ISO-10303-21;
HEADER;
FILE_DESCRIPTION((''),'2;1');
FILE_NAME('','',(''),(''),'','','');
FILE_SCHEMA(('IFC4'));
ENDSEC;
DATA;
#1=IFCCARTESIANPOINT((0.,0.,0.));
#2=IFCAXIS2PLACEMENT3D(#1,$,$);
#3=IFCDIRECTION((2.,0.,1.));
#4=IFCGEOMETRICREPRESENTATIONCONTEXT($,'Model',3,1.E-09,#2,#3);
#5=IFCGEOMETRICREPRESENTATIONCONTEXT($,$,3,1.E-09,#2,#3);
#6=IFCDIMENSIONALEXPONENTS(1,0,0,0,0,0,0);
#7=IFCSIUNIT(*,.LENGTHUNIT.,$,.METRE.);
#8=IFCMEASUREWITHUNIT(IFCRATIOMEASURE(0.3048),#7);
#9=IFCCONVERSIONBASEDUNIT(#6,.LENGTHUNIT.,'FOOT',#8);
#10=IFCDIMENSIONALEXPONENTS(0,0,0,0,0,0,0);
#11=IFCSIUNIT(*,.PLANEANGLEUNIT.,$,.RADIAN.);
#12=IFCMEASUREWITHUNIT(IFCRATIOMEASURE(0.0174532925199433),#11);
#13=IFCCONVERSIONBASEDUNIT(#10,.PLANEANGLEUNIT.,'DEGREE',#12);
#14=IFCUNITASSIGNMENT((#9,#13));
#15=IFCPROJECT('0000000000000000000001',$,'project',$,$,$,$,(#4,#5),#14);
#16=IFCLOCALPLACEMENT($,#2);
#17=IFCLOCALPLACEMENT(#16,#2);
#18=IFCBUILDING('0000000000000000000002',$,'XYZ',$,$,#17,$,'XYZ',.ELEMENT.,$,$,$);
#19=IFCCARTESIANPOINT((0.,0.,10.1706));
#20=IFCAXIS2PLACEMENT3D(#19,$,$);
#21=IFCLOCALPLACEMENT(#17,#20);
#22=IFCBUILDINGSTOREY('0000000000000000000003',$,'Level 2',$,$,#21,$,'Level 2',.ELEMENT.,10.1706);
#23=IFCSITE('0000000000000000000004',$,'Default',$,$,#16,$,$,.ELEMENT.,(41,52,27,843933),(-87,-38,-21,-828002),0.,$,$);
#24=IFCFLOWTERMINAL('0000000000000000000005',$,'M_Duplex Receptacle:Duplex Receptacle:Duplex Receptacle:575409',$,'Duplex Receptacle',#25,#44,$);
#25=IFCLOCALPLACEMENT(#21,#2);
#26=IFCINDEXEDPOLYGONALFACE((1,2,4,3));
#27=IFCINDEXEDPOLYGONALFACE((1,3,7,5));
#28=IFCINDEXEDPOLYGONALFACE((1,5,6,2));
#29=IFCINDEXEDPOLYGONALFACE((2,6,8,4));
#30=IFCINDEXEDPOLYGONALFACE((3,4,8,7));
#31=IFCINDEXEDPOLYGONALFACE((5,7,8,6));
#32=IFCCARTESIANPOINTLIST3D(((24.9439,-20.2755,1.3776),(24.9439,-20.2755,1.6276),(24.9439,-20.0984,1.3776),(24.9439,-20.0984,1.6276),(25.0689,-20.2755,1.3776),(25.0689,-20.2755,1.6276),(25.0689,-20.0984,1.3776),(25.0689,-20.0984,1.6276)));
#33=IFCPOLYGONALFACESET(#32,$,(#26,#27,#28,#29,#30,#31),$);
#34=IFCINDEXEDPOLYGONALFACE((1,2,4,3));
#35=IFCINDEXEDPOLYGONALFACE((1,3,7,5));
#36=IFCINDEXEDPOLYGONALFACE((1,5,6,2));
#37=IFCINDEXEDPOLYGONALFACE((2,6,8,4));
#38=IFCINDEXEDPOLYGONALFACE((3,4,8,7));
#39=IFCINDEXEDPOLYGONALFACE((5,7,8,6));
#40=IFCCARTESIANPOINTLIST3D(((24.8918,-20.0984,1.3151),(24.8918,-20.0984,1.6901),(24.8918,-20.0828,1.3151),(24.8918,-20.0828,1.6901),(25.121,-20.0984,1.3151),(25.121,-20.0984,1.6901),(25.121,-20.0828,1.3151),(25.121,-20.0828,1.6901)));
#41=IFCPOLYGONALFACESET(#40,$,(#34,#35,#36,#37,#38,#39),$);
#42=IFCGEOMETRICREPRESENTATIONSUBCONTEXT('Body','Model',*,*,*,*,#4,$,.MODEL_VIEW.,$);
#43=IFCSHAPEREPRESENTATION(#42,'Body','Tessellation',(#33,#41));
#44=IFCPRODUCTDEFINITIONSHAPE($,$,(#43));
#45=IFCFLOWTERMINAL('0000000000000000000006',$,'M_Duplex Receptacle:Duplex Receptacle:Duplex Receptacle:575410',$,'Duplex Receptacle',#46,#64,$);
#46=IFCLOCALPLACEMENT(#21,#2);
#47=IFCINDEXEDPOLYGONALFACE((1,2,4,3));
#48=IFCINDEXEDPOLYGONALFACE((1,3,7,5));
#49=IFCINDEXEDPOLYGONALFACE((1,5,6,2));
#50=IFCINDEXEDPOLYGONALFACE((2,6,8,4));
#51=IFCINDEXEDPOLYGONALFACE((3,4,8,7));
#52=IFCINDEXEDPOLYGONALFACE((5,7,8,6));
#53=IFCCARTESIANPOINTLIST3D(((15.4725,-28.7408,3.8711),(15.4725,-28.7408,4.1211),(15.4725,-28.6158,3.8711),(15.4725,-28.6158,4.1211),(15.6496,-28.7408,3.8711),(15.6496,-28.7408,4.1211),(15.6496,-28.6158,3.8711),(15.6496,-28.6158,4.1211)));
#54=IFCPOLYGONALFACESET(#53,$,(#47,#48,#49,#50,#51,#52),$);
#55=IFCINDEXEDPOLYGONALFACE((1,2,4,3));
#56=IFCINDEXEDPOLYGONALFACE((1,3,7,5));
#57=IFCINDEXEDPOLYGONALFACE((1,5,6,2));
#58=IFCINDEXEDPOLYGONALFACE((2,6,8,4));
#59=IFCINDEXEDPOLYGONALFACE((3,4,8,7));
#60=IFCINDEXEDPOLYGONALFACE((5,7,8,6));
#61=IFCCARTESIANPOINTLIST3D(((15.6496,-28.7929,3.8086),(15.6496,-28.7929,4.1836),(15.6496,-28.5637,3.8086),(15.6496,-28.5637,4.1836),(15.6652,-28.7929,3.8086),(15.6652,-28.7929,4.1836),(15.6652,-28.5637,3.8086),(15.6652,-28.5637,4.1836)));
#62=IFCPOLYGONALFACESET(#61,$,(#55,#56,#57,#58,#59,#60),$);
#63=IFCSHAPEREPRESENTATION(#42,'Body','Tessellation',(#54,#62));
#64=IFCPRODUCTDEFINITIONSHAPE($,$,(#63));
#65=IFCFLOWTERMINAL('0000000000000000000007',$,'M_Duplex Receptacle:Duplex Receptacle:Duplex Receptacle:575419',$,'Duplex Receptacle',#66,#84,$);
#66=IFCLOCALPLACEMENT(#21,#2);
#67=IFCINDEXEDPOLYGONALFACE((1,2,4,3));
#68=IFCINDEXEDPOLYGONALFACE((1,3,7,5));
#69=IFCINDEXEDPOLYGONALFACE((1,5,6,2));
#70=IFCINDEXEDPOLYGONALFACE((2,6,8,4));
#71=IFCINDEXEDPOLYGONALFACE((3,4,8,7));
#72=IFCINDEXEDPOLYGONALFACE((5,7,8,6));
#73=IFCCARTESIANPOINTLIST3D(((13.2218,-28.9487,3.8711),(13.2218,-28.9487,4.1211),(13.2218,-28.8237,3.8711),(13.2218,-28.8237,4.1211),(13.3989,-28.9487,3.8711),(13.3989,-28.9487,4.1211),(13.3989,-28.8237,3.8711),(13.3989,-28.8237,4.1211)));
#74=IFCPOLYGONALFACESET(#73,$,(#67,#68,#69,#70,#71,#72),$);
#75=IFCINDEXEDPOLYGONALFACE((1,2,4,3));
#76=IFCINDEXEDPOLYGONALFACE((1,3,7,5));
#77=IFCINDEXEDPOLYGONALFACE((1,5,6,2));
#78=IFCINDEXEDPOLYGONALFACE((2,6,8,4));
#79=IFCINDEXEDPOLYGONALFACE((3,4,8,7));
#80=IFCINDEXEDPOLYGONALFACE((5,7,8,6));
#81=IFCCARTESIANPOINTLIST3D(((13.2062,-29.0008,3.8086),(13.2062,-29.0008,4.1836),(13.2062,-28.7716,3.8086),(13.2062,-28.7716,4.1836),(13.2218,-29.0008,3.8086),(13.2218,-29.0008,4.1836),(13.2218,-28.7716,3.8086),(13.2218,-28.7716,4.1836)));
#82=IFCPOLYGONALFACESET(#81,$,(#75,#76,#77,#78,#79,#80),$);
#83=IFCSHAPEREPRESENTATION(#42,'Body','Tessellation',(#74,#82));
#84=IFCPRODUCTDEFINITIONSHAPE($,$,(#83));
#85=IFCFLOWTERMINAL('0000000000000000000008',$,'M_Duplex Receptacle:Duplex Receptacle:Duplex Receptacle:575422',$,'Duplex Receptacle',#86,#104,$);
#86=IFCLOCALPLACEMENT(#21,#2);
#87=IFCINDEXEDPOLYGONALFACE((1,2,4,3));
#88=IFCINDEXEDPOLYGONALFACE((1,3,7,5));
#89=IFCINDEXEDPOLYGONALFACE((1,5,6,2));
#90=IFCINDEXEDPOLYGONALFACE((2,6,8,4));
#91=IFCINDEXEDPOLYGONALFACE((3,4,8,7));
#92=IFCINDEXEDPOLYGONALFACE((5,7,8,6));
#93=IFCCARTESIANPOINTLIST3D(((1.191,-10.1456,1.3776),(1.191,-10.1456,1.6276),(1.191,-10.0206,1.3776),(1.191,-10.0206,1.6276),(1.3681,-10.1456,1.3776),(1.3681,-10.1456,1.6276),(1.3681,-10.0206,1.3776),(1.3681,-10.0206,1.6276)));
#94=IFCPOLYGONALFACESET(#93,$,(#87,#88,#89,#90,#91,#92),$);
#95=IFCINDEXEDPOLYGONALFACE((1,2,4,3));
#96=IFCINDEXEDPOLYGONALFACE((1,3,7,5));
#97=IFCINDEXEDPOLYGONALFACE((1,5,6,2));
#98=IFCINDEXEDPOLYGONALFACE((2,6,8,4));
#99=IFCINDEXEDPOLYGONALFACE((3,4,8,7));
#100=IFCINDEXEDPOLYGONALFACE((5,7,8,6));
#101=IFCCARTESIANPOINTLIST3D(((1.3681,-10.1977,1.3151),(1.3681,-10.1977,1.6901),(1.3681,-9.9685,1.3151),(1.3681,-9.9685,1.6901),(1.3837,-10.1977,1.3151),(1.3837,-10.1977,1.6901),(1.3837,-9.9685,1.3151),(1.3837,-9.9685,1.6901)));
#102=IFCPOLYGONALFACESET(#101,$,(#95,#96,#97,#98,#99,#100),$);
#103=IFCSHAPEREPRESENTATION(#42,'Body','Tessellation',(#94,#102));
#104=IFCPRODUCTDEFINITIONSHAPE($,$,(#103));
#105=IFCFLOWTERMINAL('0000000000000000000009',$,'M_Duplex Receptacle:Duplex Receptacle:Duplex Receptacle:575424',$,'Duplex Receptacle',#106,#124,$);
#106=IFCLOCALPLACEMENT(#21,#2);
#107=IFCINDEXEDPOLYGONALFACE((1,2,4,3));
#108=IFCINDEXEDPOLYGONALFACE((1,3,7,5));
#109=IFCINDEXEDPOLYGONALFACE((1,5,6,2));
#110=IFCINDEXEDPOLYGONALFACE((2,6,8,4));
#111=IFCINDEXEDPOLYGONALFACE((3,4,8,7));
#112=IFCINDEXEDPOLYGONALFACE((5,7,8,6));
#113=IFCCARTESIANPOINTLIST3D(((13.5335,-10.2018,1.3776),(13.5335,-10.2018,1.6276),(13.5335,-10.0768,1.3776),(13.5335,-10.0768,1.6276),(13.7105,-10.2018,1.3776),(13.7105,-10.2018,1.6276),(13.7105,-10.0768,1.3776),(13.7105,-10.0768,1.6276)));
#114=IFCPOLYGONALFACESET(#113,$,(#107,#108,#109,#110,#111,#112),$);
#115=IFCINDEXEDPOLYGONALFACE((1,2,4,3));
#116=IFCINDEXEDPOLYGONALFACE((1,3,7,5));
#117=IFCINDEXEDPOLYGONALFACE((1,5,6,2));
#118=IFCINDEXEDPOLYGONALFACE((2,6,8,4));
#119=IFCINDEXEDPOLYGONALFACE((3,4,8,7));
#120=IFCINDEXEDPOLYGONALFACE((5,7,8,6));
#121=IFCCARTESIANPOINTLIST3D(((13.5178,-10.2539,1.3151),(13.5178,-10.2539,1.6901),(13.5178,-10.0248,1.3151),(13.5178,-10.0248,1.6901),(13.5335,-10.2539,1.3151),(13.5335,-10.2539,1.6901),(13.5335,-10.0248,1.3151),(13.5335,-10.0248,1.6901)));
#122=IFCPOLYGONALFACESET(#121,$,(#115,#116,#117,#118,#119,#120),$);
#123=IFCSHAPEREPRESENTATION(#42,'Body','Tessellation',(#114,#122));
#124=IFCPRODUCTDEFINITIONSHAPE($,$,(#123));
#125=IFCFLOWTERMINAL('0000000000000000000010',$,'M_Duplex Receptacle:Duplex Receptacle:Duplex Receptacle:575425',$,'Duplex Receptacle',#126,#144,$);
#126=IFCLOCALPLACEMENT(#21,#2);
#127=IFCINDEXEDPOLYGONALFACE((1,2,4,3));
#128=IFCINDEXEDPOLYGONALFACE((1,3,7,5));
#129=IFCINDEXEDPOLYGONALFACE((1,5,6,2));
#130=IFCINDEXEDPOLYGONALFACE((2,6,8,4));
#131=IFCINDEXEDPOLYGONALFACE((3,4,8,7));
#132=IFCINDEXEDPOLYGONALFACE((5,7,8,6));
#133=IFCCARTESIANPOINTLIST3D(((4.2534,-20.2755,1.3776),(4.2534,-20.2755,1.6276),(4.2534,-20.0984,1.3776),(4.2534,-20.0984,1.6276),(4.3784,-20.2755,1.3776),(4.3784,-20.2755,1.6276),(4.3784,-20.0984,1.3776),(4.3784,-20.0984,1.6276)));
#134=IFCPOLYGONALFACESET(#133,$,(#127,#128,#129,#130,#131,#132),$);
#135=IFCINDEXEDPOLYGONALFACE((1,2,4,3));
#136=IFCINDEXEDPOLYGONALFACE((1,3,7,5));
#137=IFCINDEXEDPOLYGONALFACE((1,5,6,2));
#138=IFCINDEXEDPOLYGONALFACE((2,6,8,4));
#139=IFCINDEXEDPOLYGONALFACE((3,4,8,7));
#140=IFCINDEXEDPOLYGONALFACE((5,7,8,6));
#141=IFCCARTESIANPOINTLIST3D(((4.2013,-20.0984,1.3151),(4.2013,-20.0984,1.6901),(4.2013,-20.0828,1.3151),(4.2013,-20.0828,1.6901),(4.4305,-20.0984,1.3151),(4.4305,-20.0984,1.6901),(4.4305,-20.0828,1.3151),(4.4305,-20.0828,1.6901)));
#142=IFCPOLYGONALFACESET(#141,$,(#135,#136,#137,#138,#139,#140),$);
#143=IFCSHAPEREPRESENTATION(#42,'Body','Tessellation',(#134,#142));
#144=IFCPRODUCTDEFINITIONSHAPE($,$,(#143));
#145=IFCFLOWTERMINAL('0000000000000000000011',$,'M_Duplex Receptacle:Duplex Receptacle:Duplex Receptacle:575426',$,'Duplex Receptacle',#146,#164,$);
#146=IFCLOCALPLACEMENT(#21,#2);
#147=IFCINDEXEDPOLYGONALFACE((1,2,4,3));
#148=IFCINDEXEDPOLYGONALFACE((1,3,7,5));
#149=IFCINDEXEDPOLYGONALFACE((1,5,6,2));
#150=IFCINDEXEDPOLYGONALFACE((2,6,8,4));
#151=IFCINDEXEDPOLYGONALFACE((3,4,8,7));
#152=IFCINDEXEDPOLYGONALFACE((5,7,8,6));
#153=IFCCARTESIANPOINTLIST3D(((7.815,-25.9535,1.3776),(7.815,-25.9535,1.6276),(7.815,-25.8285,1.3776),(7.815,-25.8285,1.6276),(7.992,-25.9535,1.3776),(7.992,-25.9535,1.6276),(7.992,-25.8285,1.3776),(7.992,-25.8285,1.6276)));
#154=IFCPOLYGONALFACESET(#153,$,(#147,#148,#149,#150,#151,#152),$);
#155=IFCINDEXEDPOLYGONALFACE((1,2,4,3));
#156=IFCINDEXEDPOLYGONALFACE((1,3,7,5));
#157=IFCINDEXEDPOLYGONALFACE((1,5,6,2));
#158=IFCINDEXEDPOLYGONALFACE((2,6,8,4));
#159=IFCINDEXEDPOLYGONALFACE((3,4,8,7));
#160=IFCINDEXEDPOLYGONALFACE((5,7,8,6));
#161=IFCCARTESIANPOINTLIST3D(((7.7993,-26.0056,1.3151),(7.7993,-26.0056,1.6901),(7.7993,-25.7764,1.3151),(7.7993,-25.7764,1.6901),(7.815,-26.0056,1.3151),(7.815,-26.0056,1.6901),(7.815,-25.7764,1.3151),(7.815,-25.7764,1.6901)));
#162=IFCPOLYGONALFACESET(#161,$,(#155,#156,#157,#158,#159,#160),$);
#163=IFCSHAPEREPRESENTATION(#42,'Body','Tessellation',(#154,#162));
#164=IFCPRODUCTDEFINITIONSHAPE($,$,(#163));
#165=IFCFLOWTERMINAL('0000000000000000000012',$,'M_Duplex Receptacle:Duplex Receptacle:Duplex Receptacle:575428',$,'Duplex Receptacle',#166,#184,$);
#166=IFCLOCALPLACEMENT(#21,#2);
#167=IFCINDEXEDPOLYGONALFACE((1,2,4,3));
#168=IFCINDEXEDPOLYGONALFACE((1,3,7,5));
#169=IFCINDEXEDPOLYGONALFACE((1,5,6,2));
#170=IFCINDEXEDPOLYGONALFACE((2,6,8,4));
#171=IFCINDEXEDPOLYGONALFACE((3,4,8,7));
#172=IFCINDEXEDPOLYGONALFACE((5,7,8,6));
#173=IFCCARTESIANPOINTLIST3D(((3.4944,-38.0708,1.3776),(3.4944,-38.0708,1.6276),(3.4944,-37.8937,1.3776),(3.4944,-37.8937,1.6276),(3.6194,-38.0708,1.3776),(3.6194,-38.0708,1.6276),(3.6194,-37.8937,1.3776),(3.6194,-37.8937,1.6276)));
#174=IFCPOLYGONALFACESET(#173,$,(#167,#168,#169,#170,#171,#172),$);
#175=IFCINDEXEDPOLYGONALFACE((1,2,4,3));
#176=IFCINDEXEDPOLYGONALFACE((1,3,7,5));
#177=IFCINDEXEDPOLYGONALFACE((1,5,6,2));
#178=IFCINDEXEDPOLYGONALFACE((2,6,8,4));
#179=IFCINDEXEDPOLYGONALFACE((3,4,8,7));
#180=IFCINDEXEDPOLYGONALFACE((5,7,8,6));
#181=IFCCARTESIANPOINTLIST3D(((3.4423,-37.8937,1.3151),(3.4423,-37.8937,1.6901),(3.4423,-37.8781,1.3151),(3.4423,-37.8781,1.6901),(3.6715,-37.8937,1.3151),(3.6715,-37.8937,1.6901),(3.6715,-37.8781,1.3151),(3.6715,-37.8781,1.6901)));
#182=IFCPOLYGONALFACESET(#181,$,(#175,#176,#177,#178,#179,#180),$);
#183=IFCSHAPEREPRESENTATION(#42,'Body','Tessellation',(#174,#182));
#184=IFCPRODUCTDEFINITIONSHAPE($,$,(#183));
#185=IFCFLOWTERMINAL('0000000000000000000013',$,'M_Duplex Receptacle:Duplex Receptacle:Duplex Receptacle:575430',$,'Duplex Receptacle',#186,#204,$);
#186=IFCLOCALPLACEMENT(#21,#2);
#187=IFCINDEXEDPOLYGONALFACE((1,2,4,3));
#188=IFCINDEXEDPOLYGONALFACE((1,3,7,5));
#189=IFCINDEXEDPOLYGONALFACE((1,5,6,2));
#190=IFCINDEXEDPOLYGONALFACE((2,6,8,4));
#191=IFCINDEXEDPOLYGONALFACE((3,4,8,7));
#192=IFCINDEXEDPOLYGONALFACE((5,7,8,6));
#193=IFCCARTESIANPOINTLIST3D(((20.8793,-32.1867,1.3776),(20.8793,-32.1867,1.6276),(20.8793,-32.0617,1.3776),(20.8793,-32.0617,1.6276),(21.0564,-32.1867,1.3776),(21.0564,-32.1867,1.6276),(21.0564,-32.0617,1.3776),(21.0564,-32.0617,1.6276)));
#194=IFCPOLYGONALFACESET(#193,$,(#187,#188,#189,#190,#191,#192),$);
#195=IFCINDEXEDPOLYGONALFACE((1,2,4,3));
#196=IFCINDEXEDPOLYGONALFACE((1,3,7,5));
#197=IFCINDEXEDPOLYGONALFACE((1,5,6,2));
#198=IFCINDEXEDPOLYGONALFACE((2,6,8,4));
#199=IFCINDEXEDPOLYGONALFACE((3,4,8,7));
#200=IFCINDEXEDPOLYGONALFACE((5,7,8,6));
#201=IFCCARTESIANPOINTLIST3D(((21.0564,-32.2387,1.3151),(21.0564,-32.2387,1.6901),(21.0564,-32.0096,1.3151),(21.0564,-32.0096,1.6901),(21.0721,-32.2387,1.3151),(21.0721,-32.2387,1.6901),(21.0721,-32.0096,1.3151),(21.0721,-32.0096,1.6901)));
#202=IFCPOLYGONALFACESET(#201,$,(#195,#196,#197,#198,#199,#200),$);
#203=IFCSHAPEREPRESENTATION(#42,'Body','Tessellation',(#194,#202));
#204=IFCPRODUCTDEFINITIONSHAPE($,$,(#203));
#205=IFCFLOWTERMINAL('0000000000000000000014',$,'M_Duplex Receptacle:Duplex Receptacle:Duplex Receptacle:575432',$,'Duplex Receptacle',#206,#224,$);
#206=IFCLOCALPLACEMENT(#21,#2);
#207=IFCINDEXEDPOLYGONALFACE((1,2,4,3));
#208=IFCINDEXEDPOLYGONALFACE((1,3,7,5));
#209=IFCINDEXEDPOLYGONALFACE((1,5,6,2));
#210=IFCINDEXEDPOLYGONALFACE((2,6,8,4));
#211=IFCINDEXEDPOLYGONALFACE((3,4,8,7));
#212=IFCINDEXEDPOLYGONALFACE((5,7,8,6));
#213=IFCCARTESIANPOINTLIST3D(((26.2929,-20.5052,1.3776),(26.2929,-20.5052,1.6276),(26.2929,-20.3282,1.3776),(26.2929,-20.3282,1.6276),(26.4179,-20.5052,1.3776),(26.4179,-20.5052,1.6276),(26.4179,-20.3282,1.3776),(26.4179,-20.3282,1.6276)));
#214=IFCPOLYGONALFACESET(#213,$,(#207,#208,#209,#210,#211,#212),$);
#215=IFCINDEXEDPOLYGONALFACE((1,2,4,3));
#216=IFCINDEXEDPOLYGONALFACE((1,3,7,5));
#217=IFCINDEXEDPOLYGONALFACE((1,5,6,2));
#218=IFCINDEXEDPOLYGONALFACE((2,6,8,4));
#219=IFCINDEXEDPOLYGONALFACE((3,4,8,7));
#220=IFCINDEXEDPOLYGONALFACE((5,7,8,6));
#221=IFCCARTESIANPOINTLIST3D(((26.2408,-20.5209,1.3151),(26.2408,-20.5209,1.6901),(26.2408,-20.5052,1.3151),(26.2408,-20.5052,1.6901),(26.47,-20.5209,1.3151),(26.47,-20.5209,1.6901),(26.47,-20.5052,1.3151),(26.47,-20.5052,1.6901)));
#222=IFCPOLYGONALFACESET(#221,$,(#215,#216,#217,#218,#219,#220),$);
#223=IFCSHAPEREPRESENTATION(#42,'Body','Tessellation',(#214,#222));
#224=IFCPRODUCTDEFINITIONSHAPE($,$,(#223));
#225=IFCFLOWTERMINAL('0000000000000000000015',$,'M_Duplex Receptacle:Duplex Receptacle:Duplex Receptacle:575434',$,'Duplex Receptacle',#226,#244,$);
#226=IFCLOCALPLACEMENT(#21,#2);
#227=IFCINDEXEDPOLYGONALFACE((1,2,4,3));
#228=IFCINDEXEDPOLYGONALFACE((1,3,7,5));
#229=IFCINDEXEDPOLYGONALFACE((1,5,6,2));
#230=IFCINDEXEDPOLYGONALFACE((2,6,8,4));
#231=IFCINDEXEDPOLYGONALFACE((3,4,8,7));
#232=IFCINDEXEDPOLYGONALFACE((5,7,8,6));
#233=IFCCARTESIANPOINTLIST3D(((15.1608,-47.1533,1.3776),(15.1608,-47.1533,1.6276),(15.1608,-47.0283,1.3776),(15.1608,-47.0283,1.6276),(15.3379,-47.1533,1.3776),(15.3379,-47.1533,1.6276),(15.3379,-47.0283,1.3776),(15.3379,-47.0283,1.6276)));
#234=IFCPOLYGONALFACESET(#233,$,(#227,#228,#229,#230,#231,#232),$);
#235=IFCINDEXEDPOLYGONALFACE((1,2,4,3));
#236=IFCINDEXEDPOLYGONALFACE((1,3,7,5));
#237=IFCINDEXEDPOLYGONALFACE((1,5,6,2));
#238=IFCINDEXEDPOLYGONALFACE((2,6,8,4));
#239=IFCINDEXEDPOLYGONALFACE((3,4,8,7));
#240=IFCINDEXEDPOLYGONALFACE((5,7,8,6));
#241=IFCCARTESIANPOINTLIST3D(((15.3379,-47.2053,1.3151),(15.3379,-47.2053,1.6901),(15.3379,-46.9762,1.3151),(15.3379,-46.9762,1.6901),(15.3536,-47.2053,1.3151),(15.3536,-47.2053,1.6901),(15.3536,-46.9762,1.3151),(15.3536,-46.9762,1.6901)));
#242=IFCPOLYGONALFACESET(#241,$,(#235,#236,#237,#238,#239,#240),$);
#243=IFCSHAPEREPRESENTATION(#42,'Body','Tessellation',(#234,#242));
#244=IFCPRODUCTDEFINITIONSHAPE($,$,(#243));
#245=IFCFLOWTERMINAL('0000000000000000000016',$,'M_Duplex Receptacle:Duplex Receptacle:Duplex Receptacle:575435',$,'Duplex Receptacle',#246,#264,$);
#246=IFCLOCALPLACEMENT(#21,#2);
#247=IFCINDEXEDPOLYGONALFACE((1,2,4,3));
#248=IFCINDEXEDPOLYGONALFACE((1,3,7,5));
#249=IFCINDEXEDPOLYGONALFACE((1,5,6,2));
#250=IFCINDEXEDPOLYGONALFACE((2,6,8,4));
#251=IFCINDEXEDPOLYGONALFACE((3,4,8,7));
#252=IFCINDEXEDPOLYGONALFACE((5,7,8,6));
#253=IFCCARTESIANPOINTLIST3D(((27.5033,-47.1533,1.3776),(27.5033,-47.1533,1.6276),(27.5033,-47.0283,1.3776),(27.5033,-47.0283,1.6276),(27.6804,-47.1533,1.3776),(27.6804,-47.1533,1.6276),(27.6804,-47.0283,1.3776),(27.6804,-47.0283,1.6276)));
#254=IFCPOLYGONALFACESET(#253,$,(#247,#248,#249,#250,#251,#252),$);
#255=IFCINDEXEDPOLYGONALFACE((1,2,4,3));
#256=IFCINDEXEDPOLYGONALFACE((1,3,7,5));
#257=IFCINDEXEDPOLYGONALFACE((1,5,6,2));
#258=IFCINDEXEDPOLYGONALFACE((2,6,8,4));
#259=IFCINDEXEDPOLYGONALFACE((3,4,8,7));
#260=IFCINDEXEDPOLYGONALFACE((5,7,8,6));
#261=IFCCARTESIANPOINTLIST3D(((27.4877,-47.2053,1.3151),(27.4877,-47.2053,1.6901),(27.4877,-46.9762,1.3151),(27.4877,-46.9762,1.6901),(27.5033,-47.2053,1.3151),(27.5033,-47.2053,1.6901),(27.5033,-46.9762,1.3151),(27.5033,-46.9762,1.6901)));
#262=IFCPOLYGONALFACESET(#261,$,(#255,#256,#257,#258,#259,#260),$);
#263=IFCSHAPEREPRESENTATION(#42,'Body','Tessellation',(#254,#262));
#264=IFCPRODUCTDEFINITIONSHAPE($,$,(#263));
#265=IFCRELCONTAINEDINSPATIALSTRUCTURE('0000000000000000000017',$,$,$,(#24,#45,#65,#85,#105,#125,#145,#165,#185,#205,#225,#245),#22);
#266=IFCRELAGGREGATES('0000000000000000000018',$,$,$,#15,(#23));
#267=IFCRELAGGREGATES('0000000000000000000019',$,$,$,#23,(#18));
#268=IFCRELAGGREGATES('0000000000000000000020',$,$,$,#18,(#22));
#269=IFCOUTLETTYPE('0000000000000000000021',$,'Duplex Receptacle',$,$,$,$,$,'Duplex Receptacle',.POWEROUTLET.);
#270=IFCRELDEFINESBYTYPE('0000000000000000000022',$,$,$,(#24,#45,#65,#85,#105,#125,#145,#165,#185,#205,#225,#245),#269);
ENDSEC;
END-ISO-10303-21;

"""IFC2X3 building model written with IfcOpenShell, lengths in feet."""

from ifc_helpers import new_model, entity, si_unit, converted_unit, direction, frame, frame_2d, origin, origin_2d_with_axis, place, context, subcontext, project, spatial, rectangle, extrude, source, transform, mapped, type_object, type_shapes, element, save


model = new_model("IFC2X3")

# Units and contexts
model_context = context("Model", 3, precision=1e-09, world=origin(), true_north=direction((2.0, 0.0, 1.0)))
context_of_model = context(None, 3, precision=1e-09, world=origin(), true_north=direction((2.0, 0.0, 1.0)))
body_context = subcontext(model_context, "Body", "Model", "MODEL_VIEW")
ifc_project = project(units=[converted_unit("LENGTHUNIT", "FOOT", entity("IfcRatioMeasure", 0.3048), si_unit("LENGTHUNIT", "METRE"), dimensions=[1, 0, 0, 0, 0, 0, 0]), converted_unit("PLANEANGLEUNIT", "DEGREE", entity("IfcRatioMeasure", 0.0174532925199433), si_unit("PLANEANGLEUNIT", "RADIAN"), dimensions=[0, 0, 0, 0, 0, 0, 0])], contexts=[model_context, context_of_model])

# Site, building, storey
site_placement = place(None, origin())
site = spatial("IfcSite", under=ifc_project, at=site_placement, Name="Default", CompositionType="ELEMENT", RefLatitude=(41, 52, 27, 843933), RefLongitude=(-87, -38, -21, -828002), RefElevation=0.0)
building_placement = place(site_placement, origin())
building = spatial("IfcBuilding", under=site, at=building_placement, Name="XYZ", LongName="XYZ", CompositionType="ELEMENT")
storey_placement = place(building_placement, frame((0.0, 0.0, 10.1706)))
storey = spatial("IfcBuildingStorey", under=building, at=storey_placement, Name="Level 2", LongName="Level 2", CompositionType="ELEMENT", Elevation=10.1706)

# Flow terminals
outlet_type = type_object("IfcOutletType", Name="Duplex Receptacle", ElementType="Duplex Receptacle", PredefinedType="POWEROUTLET")
shared_shape_1 = source(origin(), body_context, "Body", "SweptSolid", [
    extrude(rectangle(XDim=0.125, YDim=0.25, at=origin_2d_with_axis()), frame((0.0, 0.0, -0.1771), z_axis=(0.0, 0.0, 1.0), x_axis=(-1.0, 0.0, 0.0)), (0.0, 0.0, 1.0), 0.1771),
    extrude(rectangle(XDim=0.2292, YDim=0.375, at=frame_2d((0.0, 0.0), x_axis=(1.0, 0.0))), frame((0.0, 0.0, 0.0), z_axis=(0.0, 0.0, 1.0), x_axis=(-1.0, 0.0, 0.0)), (0.0, 0.0, 1.0), 0.0156),
])
type_shapes(outlet_type, [shared_shape_1])
for number, where, z_axis, x_axis, name in (
    (1, (25.0064, -20.0984, 1.5026), (0.0, 1.0, 0.0), (-1.0, 0.0, 0.0), "M_Duplex Receptacle:Duplex Receptacle:Duplex Receptacle:575409"),
    (2, (15.6496, -28.6783, 3.9961), (1.0, 0.0, 0.0), (0.0, 1.0, 0.0), "M_Duplex Receptacle:Duplex Receptacle:Duplex Receptacle:575410"),
    (3, (13.2218, -28.8862, 3.9961), (-1.0, 0.0, 0.0), (0.0, -1.0, 0.0), "M_Duplex Receptacle:Duplex Receptacle:Duplex Receptacle:575419"),
    (4, (1.3681, -10.0831, 1.5026), (1.0, 0.0, 0.0), (0.0, 1.0, 0.0), "M_Duplex Receptacle:Duplex Receptacle:Duplex Receptacle:575422"),
    (5, (13.5335, -10.1393, 1.5026), (-1.0, 0.0, 0.0), (0.0, -1.0, 0.0), "M_Duplex Receptacle:Duplex Receptacle:Duplex Receptacle:575424"),
    (6, (4.3159, -20.0984, 1.5026), (0.0, 1.0, 0.0), (-1.0, 0.0, 0.0), "M_Duplex Receptacle:Duplex Receptacle:Duplex Receptacle:575425"),
    (7, (7.815, -25.891, 1.5026), (-1.0, 0.0, 0.0), (0.0, -1.0, 0.0), "M_Duplex Receptacle:Duplex Receptacle:Duplex Receptacle:575426"),
    (8, (3.5569, -37.8937, 1.5026), (0.0, 1.0, 0.0), (-1.0, 0.0, 0.0), "M_Duplex Receptacle:Duplex Receptacle:Duplex Receptacle:575428"),
    (9, (21.0564, -32.1242, 1.5026), (1.0, 0.0, 0.0), (0.0, 1.0, 0.0), "M_Duplex Receptacle:Duplex Receptacle:Duplex Receptacle:575430"),
    (10, (26.3554, -20.5052, 1.5026), (0.0, -1.0, 0.0), (1.0, 0.0, 0.0), "M_Duplex Receptacle:Duplex Receptacle:Duplex Receptacle:575432"),
    (11, (15.3379, -47.0908, 1.5026), (1.0, 0.0, 0.0), (0.0, 1.0, 0.0), "M_Duplex Receptacle:Duplex Receptacle:Duplex Receptacle:575434"),
    (12, (27.5033, -47.0908, 1.5026), (-1.0, 0.0, 0.0), (0.0, -1.0, 0.0), "M_Duplex Receptacle:Duplex Receptacle:Duplex Receptacle:575435"),
):
    element("IfcFlowTerminal", number, at=place(storey_placement, frame(where, z_axis=z_axis, x_axis=x_axis)), inside=storey, type_object=outlet_type, Name=name, ObjectType="Duplex Receptacle", context=body_context, shape_type="MappedRepresentation", body=[
        mapped(shared_shape_1, transform((0.0, 0.0, 0.0), scale=1.0)),
    ])

save(model, "model.ifc")
